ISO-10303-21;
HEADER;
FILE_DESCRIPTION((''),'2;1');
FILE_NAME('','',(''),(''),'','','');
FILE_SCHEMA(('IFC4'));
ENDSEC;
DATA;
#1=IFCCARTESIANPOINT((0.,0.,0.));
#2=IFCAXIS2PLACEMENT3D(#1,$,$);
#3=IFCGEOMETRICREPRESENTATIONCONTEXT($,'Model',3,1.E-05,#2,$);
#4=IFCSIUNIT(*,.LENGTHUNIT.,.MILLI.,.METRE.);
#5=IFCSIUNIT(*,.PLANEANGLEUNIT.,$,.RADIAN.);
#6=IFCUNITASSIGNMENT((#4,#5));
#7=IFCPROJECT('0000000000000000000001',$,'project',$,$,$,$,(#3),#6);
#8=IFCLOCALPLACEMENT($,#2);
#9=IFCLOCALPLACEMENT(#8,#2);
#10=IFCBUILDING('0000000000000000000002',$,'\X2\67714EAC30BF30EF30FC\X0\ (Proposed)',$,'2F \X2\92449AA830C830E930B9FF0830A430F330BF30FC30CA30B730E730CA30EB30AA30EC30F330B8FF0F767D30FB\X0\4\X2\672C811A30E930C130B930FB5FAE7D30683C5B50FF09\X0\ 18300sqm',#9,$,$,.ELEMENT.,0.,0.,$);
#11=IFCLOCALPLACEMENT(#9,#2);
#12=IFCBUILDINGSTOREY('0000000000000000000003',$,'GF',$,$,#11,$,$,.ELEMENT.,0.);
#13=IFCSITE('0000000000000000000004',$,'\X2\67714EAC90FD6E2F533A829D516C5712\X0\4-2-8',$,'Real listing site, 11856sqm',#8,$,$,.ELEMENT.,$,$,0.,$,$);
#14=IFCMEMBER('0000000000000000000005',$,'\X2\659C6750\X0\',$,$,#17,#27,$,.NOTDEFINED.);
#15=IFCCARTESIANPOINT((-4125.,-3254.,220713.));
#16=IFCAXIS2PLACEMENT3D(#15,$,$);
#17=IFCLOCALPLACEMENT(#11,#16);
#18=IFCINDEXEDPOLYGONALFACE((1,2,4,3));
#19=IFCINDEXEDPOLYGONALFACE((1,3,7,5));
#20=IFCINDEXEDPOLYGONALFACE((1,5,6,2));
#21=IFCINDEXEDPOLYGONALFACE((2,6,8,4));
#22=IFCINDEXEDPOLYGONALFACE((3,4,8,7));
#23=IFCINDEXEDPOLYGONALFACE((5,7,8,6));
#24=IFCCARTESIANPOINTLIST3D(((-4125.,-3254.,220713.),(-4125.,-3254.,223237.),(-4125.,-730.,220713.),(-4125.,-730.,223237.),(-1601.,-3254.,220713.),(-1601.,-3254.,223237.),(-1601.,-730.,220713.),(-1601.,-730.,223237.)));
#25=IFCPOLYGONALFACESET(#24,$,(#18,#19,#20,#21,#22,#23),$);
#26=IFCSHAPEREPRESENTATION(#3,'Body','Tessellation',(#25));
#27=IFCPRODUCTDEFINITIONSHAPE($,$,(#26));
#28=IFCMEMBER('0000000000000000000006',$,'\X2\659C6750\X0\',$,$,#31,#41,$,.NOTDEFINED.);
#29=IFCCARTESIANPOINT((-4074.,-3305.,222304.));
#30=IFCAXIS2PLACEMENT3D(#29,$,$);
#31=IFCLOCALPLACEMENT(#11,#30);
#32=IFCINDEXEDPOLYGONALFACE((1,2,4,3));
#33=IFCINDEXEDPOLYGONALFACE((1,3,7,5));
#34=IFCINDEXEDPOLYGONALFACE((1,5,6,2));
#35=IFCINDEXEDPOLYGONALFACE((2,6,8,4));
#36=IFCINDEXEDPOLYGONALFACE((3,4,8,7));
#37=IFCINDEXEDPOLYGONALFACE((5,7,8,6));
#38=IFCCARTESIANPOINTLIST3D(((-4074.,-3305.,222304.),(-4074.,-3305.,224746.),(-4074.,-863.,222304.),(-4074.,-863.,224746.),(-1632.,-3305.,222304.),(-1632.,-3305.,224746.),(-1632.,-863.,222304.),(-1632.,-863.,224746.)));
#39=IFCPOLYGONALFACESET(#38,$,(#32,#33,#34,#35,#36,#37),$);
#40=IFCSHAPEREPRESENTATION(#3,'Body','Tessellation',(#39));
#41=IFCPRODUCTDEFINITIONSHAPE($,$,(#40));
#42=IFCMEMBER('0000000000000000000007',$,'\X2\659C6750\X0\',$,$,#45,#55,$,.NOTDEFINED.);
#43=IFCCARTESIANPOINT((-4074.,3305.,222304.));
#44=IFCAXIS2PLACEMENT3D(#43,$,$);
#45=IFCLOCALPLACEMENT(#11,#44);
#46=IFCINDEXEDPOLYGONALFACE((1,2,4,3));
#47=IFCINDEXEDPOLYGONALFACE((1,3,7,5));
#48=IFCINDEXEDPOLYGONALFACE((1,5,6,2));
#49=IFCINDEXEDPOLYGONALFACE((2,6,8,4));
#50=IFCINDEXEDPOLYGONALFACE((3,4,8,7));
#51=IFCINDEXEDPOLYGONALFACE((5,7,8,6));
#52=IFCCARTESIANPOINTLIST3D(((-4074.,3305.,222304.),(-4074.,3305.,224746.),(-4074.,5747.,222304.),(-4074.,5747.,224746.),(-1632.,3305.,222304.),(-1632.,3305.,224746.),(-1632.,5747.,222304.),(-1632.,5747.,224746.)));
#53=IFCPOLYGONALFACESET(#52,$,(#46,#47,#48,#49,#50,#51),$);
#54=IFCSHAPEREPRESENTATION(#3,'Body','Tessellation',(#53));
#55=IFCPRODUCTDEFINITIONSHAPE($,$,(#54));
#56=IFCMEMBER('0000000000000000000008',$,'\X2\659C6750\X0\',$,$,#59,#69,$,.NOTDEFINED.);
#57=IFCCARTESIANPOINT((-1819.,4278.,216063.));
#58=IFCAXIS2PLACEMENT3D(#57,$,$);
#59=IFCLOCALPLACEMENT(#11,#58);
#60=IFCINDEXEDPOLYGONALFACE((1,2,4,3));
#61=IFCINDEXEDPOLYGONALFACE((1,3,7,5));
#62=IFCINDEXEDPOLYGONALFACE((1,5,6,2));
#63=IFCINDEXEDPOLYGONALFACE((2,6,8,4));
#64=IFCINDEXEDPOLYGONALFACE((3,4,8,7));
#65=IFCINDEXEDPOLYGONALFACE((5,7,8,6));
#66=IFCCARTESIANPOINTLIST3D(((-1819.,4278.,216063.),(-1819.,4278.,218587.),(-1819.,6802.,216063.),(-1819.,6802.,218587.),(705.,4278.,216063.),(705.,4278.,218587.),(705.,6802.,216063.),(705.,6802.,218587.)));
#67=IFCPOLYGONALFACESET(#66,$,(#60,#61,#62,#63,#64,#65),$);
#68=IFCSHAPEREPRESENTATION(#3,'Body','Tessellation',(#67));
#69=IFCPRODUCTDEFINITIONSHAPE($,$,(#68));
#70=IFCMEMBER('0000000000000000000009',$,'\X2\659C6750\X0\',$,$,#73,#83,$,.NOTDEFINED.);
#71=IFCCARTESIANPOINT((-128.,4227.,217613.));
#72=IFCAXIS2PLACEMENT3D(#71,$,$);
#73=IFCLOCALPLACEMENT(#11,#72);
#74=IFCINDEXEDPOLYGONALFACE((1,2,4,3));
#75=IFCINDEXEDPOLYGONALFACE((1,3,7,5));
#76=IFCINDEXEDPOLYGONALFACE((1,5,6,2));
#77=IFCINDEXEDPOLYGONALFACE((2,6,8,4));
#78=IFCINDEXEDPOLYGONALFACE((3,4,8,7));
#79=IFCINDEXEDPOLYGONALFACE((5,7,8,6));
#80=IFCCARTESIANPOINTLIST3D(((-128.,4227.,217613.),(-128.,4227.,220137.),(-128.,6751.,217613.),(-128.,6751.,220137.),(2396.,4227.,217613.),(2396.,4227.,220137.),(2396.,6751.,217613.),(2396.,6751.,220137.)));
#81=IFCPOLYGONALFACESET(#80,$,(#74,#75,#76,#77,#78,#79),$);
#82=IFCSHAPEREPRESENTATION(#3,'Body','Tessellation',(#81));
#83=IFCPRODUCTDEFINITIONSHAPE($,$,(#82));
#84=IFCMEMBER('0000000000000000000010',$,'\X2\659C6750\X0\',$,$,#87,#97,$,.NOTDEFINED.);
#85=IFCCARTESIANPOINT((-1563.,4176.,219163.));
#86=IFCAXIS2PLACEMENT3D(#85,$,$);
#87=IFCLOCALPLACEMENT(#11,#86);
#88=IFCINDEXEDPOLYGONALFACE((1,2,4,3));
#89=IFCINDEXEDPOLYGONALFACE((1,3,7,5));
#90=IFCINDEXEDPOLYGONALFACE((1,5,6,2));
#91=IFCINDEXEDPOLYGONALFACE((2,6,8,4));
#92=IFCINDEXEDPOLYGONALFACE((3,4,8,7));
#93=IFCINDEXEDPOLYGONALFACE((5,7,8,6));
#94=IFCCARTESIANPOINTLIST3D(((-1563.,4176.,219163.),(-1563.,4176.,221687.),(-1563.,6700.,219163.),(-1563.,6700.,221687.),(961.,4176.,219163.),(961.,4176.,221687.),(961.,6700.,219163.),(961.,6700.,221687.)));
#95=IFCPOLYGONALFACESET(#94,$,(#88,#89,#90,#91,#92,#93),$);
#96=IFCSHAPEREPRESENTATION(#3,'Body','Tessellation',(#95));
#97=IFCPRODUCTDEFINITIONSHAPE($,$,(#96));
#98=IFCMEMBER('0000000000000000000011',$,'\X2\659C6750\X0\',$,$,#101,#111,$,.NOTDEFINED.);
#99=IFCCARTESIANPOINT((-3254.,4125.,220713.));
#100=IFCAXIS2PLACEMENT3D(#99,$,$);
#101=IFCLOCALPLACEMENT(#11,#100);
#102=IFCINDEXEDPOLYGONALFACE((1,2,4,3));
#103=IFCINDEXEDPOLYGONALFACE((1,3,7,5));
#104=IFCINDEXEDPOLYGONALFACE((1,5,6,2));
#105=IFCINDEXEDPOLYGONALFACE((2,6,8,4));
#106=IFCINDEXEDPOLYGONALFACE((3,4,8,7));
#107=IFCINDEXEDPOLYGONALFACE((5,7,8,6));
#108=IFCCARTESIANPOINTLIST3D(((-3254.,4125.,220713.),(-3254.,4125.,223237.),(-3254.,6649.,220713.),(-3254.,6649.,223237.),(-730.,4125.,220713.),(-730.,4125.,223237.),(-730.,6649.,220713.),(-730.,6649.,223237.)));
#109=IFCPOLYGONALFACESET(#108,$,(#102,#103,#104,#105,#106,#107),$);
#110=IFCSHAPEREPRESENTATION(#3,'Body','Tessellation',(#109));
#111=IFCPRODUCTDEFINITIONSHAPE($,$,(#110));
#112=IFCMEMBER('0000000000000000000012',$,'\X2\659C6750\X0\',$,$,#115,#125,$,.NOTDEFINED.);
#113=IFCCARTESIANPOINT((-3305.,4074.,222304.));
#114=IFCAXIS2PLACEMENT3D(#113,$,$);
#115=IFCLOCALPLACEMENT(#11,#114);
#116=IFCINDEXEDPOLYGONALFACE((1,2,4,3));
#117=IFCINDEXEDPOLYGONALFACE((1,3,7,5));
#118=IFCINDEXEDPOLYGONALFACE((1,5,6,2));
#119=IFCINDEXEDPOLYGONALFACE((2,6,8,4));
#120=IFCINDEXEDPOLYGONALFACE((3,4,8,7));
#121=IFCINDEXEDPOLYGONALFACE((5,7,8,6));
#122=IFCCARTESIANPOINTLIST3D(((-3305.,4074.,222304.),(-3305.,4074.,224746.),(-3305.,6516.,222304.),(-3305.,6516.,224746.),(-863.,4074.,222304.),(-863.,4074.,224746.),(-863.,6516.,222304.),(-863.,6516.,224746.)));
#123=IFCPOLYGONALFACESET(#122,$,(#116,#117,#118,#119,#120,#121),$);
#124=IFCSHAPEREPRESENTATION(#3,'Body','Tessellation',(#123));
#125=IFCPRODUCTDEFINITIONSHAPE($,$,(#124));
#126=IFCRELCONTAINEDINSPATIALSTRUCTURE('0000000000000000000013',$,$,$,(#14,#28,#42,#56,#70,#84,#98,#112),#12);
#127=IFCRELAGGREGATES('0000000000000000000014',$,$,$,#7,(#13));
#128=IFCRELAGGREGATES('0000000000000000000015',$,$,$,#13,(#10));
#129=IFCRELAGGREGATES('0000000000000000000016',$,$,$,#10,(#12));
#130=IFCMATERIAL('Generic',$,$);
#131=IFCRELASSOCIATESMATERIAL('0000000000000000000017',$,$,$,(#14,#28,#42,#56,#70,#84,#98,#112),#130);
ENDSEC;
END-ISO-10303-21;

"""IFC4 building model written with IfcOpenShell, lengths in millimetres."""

from ifc_helpers import new_model, si_unit, frame, frame_2d, origin, place, context, project, spatial, rectangle, extrude, material, element, save


model = new_model("IFC4")

# Units and contexts
model_context = context("Model", 3, precision=1e-05, world=origin())
ifc_project = project(units=[si_unit("LENGTHUNIT", "METRE", prefix="MILLI"), si_unit("PLANEANGLEUNIT", "RADIAN")], contexts=[model_context])

# Site, building, storey
site_placement = place(None, origin())
site = spatial("IfcSite", under=ifc_project, at=site_placement, Name="東京都港区芝公園4-2-8", ObjectType="Real listing site, 11856sqm", CompositionType="ELEMENT", RefElevation=0.0)
building_placement = place(site_placement, origin())
building = spatial("IfcBuilding", under=site, at=building_placement, Name="東京タワー (Proposed)", ObjectType="2F 鉄骨トラス（インターナショナルオレンジ／白・4本脚ラチス・微細格子） 18300sqm", CompositionType="ELEMENT", ElevationOfRefHeight=0.0, ElevationOfTerrain=0.0)
storey_placement = place(building_placement, origin())
storey = spatial("IfcBuildingStorey", under=building, at=storey_placement, Name="GF", CompositionType="ELEMENT", Elevation=0.0)

# Shared definitions
ifc_material = material(Name="Generic")

# Members
member_1_placement = place(storey_placement, frame((-4125.0, -3254.0, 220713.0)))
element("IfcMember", 1, at=member_1_placement, inside=storey, material=ifc_material, Name="斜材", PredefinedType="NOTDEFINED", context=model_context, shape_type="SweptSolid", body=[
    extrude(rectangle(XDim=2524.0, YDim=2524.0, at=frame_2d((1262.0, 1262.0))), frame((-4125.0, -3254.0, 220713.0)), (0.0, 0.0, 1.0), 2524.0),
])
member_2_placement = place(storey_placement, frame((-4074.0, -3305.0, 222304.0)))
element("IfcMember", 2, at=member_2_placement, inside=storey, material=ifc_material, Name="斜材", PredefinedType="NOTDEFINED", context=model_context, shape_type="SweptSolid", body=[
    extrude(rectangle(XDim=2442.0, YDim=2442.0, at=frame_2d((1221.0, 1221.0))), frame((-4074.0, -3305.0, 222304.0)), (0.0, 0.0, 1.0), 2442.0),
])
member_3_placement = place(storey_placement, frame((-4074.0, 3305.0, 222304.0)))
element("IfcMember", 3, at=member_3_placement, inside=storey, material=ifc_material, Name="斜材", PredefinedType="NOTDEFINED", context=model_context, shape_type="SweptSolid", body=[
    extrude(rectangle(XDim=2442.0, YDim=2442.0, at=frame_2d((1221.0, 1221.0))), frame((-4074.0, 3305.0, 222304.0)), (0.0, 0.0, 1.0), 2442.0),
])
member_4_placement = place(storey_placement, frame((-1819.0, 4278.0, 216063.0)))
element("IfcMember", 4, at=member_4_placement, inside=storey, material=ifc_material, Name="斜材", PredefinedType="NOTDEFINED", context=model_context, shape_type="SweptSolid", body=[
    extrude(rectangle(XDim=2524.0, YDim=2524.0, at=frame_2d((1262.0, 1262.0))), frame((-1819.0, 4278.0, 216063.0)), (0.0, 0.0, 1.0), 2524.0),
])
member_5_placement = place(storey_placement, frame((-128.0, 4227.0, 217613.0)))
element("IfcMember", 5, at=member_5_placement, inside=storey, material=ifc_material, Name="斜材", PredefinedType="NOTDEFINED", context=model_context, shape_type="SweptSolid", body=[
    extrude(rectangle(XDim=2524.0, YDim=2524.0, at=frame_2d((1262.0, 1262.0))), frame((-128.0, 4227.0, 217613.0)), (0.0, 0.0, 1.0), 2524.0),
])
member_6_placement = place(storey_placement, frame((-1563.0, 4176.0, 219163.0)))
element("IfcMember", 6, at=member_6_placement, inside=storey, material=ifc_material, Name="斜材", PredefinedType="NOTDEFINED", context=model_context, shape_type="SweptSolid", body=[
    extrude(rectangle(XDim=2524.0, YDim=2524.0, at=frame_2d((1262.0, 1262.0))), frame((-1563.0, 4176.0, 219163.0)), (0.0, 0.0, 1.0), 2524.0),
])
member_7_placement = place(storey_placement, frame((-3254.0, 4125.0, 220713.0)))
element("IfcMember", 7, at=member_7_placement, inside=storey, material=ifc_material, Name="斜材", PredefinedType="NOTDEFINED", context=model_context, shape_type="SweptSolid", body=[
    extrude(rectangle(XDim=2524.0, YDim=2524.0, at=frame_2d((1262.0, 1262.0))), frame((-3254.0, 4125.0, 220713.0)), (0.0, 0.0, 1.0), 2524.0),
])
member_8_placement = place(storey_placement, frame((-3305.0, 4074.0, 222304.0)))
element("IfcMember", 8, at=member_8_placement, inside=storey, material=ifc_material, Name="斜材", PredefinedType="NOTDEFINED", context=model_context, shape_type="SweptSolid", body=[
    extrude(rectangle(XDim=2442.0, YDim=2442.0, at=frame_2d((1221.0, 1221.0))), frame((-3305.0, 4074.0, 222304.0)), (0.0, 0.0, 1.0), 2442.0),
])

save(model, "model.ifc")
